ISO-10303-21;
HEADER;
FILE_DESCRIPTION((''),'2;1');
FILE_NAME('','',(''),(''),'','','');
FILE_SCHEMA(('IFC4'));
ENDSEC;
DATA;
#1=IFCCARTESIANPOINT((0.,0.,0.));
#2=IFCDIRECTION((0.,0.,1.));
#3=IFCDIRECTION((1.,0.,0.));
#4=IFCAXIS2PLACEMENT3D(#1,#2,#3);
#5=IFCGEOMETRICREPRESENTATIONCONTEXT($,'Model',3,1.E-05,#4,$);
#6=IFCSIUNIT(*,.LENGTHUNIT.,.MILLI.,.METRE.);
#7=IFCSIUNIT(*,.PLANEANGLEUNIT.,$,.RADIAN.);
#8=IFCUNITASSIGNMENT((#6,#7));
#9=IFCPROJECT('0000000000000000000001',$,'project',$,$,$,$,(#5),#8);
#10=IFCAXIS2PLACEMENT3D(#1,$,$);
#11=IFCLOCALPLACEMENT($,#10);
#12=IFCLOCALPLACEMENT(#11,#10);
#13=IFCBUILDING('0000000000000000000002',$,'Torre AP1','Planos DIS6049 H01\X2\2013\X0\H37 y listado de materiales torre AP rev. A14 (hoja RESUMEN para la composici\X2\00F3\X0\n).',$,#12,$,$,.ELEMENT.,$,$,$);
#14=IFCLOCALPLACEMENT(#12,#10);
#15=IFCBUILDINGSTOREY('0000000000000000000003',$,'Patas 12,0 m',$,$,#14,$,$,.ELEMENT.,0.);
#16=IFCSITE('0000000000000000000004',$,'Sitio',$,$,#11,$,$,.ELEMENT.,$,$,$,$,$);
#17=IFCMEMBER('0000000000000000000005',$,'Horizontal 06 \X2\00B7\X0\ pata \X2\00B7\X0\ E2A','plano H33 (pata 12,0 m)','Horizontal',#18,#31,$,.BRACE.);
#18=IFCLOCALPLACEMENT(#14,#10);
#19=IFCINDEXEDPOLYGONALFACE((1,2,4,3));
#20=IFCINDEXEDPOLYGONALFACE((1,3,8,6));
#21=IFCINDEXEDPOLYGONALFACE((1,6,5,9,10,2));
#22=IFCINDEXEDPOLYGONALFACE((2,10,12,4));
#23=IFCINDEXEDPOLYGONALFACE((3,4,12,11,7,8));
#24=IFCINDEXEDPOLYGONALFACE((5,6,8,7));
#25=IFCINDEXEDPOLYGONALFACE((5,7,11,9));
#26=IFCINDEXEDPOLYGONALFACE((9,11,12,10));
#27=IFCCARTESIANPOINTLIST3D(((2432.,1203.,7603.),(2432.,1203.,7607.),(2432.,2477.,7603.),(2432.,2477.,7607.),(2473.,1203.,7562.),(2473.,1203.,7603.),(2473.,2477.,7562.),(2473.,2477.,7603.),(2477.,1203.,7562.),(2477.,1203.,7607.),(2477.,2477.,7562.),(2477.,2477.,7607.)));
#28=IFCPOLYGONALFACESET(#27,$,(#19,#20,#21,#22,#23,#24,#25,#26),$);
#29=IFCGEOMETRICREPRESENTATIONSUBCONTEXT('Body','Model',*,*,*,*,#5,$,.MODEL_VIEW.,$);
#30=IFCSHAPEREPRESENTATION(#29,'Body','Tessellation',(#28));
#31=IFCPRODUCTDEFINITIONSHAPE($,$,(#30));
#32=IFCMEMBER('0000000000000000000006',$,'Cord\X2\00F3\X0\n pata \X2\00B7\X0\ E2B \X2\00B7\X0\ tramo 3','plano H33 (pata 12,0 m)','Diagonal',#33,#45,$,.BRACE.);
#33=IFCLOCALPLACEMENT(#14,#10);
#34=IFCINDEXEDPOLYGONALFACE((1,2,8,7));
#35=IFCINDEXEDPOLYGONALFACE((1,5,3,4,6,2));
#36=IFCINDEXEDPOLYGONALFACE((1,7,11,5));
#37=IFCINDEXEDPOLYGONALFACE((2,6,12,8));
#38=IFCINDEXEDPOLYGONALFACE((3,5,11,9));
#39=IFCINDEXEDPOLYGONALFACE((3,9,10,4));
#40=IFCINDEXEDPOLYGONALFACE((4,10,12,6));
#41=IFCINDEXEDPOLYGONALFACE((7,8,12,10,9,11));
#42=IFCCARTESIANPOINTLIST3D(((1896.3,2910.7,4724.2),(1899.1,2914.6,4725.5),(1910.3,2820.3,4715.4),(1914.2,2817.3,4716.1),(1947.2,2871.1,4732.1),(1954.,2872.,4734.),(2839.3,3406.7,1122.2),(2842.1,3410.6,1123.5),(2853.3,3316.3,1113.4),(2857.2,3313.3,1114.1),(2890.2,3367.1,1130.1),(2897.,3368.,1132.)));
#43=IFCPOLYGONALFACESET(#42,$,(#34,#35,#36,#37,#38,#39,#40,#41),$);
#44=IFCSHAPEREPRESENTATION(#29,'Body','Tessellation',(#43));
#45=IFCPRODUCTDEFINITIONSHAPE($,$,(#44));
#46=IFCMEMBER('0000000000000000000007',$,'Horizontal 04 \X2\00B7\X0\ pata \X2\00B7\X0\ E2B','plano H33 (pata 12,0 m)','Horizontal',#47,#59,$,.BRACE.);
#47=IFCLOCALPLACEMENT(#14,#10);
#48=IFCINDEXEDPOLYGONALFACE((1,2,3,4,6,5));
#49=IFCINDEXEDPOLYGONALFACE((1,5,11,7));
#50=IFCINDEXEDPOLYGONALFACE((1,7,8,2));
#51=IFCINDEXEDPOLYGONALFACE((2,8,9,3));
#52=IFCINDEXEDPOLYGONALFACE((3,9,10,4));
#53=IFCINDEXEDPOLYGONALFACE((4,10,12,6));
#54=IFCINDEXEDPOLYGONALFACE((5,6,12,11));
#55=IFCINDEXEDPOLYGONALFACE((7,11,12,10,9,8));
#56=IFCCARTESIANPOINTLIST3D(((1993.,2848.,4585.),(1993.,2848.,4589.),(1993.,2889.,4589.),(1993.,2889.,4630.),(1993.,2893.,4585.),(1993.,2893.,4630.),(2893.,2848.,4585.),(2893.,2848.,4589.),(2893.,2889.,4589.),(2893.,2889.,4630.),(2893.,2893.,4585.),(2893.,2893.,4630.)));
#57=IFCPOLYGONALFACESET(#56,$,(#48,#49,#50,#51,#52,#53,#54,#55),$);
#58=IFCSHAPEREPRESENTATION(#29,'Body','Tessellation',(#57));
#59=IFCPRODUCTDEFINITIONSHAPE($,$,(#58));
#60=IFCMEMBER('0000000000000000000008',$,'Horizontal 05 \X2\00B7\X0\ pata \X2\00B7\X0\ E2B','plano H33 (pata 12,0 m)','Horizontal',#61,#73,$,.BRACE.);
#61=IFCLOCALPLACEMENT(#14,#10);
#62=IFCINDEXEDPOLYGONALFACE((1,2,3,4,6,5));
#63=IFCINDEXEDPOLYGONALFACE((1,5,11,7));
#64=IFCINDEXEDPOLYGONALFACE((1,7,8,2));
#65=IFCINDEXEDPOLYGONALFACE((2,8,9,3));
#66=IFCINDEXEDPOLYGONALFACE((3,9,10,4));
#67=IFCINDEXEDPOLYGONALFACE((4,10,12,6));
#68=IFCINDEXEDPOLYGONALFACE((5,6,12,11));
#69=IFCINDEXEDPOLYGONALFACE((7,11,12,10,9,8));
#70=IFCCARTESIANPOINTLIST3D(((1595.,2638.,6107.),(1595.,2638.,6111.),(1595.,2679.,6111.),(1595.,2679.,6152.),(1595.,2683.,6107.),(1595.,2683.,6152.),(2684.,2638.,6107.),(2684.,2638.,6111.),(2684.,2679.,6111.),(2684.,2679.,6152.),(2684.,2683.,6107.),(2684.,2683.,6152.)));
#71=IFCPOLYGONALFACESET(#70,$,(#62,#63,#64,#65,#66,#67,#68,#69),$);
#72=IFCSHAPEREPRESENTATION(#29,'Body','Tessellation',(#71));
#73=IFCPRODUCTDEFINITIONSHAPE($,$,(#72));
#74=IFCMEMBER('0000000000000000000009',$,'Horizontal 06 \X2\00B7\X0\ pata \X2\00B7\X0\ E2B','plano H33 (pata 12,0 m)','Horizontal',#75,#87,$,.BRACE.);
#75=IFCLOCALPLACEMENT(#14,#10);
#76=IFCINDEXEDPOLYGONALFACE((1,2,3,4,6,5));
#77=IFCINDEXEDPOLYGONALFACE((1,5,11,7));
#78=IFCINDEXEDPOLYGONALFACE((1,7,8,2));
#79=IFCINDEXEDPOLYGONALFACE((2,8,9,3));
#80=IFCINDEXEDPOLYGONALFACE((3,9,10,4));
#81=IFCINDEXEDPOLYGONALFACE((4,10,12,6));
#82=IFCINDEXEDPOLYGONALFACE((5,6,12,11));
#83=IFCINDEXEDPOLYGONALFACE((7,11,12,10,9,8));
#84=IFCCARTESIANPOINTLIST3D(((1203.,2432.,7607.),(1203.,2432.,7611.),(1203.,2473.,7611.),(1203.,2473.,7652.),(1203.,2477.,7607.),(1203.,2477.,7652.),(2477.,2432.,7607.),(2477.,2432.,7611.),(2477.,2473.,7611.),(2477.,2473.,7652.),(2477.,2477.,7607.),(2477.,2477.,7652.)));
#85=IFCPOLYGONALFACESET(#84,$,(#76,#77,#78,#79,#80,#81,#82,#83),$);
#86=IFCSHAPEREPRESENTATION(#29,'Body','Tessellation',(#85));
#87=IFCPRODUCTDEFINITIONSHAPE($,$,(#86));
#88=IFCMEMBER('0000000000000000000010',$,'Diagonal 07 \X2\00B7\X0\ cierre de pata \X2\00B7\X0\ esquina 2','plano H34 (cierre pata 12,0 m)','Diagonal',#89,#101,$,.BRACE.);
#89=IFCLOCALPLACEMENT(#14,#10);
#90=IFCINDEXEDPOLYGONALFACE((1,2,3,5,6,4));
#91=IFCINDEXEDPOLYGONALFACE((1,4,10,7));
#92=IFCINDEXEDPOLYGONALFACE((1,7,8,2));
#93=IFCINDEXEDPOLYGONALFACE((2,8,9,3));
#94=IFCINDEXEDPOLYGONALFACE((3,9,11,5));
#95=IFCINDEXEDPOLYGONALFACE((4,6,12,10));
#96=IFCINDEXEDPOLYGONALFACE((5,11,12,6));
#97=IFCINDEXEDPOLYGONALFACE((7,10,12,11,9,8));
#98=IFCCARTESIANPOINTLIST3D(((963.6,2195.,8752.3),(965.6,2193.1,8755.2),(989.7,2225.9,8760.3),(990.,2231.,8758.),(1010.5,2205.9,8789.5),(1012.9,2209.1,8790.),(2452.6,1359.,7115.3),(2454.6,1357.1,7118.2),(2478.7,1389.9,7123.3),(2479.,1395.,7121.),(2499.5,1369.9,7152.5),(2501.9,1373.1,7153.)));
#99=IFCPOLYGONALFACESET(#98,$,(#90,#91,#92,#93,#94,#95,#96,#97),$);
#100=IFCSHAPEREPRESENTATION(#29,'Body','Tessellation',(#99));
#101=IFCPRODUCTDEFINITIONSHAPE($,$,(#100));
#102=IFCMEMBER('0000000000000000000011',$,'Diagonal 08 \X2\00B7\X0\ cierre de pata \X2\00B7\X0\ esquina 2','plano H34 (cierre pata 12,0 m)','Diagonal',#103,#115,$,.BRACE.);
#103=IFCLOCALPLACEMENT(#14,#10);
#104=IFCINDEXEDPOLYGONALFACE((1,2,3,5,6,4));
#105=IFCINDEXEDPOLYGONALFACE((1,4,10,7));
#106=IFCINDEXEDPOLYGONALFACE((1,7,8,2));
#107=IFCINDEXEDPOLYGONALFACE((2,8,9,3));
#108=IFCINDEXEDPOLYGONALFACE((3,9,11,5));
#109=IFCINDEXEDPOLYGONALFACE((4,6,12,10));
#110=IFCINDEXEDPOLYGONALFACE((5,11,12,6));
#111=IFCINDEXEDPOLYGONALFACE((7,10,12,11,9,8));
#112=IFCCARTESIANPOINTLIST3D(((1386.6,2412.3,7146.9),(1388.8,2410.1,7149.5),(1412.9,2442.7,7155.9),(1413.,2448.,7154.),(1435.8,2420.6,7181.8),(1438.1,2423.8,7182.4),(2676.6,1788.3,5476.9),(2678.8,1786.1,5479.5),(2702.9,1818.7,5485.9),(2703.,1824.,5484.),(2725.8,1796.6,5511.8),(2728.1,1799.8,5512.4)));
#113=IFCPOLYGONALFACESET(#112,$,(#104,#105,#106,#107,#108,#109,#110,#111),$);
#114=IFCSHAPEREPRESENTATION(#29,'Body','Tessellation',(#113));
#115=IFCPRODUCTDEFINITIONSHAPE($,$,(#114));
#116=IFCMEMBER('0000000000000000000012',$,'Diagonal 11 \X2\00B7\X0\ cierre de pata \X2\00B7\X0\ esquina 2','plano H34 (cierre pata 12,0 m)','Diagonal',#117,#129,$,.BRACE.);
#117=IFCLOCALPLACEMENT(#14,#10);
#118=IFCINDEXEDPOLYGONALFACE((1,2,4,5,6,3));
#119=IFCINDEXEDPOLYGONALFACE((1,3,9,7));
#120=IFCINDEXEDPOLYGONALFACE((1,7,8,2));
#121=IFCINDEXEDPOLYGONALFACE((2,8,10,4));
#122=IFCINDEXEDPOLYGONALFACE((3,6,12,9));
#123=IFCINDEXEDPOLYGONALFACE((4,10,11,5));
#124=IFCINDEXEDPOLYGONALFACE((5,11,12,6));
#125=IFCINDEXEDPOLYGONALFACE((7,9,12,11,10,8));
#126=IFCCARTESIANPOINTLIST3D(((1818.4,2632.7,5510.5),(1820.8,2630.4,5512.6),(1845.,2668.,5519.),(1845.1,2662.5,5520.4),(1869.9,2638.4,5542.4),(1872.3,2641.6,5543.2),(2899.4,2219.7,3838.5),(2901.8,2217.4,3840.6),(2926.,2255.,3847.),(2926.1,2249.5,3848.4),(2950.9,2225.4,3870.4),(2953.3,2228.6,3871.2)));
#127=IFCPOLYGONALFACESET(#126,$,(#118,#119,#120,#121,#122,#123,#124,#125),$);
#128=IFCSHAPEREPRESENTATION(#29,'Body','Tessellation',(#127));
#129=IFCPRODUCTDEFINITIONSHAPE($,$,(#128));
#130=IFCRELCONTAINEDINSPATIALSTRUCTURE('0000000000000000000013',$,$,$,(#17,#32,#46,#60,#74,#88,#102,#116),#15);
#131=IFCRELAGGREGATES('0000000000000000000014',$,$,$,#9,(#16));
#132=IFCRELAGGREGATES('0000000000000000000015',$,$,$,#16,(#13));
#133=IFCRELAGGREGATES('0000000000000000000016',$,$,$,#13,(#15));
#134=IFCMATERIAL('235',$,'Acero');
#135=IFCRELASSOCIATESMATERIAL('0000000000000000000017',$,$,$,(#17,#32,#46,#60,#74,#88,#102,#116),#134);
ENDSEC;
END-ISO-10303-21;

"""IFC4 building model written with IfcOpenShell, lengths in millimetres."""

from ifc_helpers import new_model, si_unit, frame, frame_2d, origin, origin_with_axes, place, context, subcontext, project, spatial, l_section, extrude, material, element, save


model = new_model("IFC4")

# Units and contexts
model_context = context("Model", 3, precision=1e-05, world=origin_with_axes())
body_context = subcontext(model_context, "Body", "Model", "MODEL_VIEW")
ifc_project = project(units=[si_unit("LENGTHUNIT", "METRE", prefix="MILLI"), si_unit("PLANEANGLEUNIT", "RADIAN")], contexts=[model_context])

# Site, building, storey
site_placement = place(None, origin())
site = spatial("IfcSite", under=ifc_project, at=site_placement, Name="Sitio", CompositionType="ELEMENT")
building_placement = place(site_placement, origin())
building = spatial("IfcBuilding", under=site, at=building_placement, Name="Torre AP1", Description="Planos DIS6049 H01–H37 y listado de materiales torre AP rev. A14 (hoja RESUMEN para la composición).", CompositionType="ELEMENT")
storey_placement = place(building_placement, origin())
storey = spatial("IfcBuildingStorey", under=building, at=storey_placement, Name="Patas 12,0 m", CompositionType="ELEMENT", Elevation=0.0)

# Members
ifc_material = material(Name="235", Category="Acero")
member_1_placement = place(storey_placement, frame((2477.0, 2477.0, 7607.0), z_axis=(0.0, -1.0, 0.0), x_axis=(-1.0, 0.0, 0.0)))
element("IfcMember", 1, at=member_1_placement, inside=storey, material=ifc_material, Name="Horizontal 06 · pata · E2A", Description="plano H33 (pata 12,0 m)", ObjectType="Horizontal", PredefinedType="BRACE", context=body_context, shape_type="SweptSolid", body=[
    extrude(l_section(Depth=45.0, Width=45.0, Thickness=4.0, at=frame_2d((22.5, 22.5))), None, (0.0, 0.0, 1.0), 1274.0),
])
member_2_placement = place(storey_placement, frame((1954.0, 2872.0, 4734.0), z_axis=(0.251046, 0.132045, -0.958926), x_axis=(-0.56819, -0.781925, -0.256424)))
element("IfcMember", 2, at=member_2_placement, inside=storey, material=ifc_material, Name="Cordón pata · E2B · tramo 3", Description="plano H33 (pata 12,0 m)", ObjectType="Diagonal", PredefinedType="BRACE", context=body_context, shape_type="SweptSolid", body=[
    extrude(l_section(Depth=70.0, Width=70.0, Thickness=5.0, at=frame_2d((35.0, 35.0))), None, (0.0, 0.0, 1.0), 3756.3),
])
member_3_placement = place(storey_placement, frame((2893.0, 2893.0, 4585.0), z_axis=(-1.0, 0.0, 0.0), x_axis=(0.0, -1.0, 0.0)))
element("IfcMember", 3, at=member_3_placement, inside=storey, material=ifc_material, Name="Horizontal 04 · pata · E2B", Description="plano H33 (pata 12,0 m)", ObjectType="Horizontal", PredefinedType="BRACE", context=body_context, shape_type="SweptSolid", body=[
    extrude(l_section(Depth=45.0, Width=45.0, Thickness=4.0, at=frame_2d((22.5, 22.5))), None, (0.0, 0.0, 1.0), 900.0),
])
member_4_placement = place(storey_placement, frame((2684.0, 2683.0, 6107.0), z_axis=(-1.0, 0.0, 0.0), x_axis=(0.0, -1.0, 0.0)))
element("IfcMember", 4, at=member_4_placement, inside=storey, material=ifc_material, Name="Horizontal 05 · pata · E2B", Description="plano H33 (pata 12,0 m)", ObjectType="Horizontal", PredefinedType="BRACE", context=body_context, shape_type="SweptSolid", body=[
    extrude(l_section(Depth=45.0, Width=45.0, Thickness=4.0, at=frame_2d((22.5, 22.5))), None, (0.0, 0.0, 1.0), 1089.0),
])
member_5_placement = place(storey_placement, frame((2477.0, 2477.0, 7607.0), z_axis=(-1.0, 0.0, 0.0), x_axis=(0.0, -1.0, 0.0)))
element("IfcMember", 5, at=member_5_placement, inside=storey, material=ifc_material, Name="Horizontal 06 · pata · E2B", Description="plano H33 (pata 12,0 m)", ObjectType="Horizontal", PredefinedType="BRACE", context=body_context, shape_type="SweptSolid", body=[
    extrude(l_section(Depth=45.0, Width=45.0, Thickness=4.0, at=frame_2d((22.5, 22.5))), None, (0.0, 0.0, 1.0), 1274.0),
])
member_6_placement = place(storey_placement, frame((2479.0, 1395.0, 7121.0), z_axis=(-0.629454, 0.353407, 0.692019), x_axis=(-0.587707, -0.799129, -0.126466)))
element("IfcMember", 6, at=member_6_placement, inside=storey, material=ifc_material, Name="Diagonal 07 · cierre de pata · esquina 2", Description="plano H34 (cierre pata 12,0 m)", ObjectType="Diagonal", PredefinedType="BRACE", context=body_context, shape_type="SweptSolid", body=[
    extrude(l_section(Depth=45.0, Width=45.0, Thickness=4.0, at=frame_2d((22.5, 22.5))), None, (0.0, 0.0, 1.0), 2365.5),
])
member_7_placement = place(storey_placement, frame((2703.0, 1824.0, 5484.0), z_axis=(-0.58622, 0.283567, 0.758905), x_axis=(-0.587278, -0.794021, -0.156957)))
element("IfcMember", 7, at=member_7_placement, inside=storey, material=ifc_material, Name="Diagonal 08 · cierre de pata · esquina 2", Description="plano H34 (cierre pata 12,0 m)", ObjectType="Diagonal", PredefinedType="BRACE", context=body_context, shape_type="SweptSolid", body=[
    extrude(l_section(Depth=45.0, Width=45.0, Thickness=4.0, at=frame_2d((22.5, 22.5))), None, (0.0, 0.0, 1.0), 2200.5),
])
member_8_placement = place(storey_placement, frame((2926.0, 2255.0, 3847.0), z_axis=(-0.531622, 0.203108, 0.822268), x_axis=(-0.591842, -0.783559, -0.189098)))
element("IfcMember", 8, at=member_8_placement, inside=storey, material=ifc_material, Name="Diagonal 11 · cierre de pata · esquina 2", Description="plano H34 (cierre pata 12,0 m)", ObjectType="Diagonal", PredefinedType="BRACE", context=body_context, shape_type="SweptSolid", body=[
    extrude(l_section(Depth=45.0, Width=45.0, Thickness=4.0, at=frame_2d((22.5, 22.5))), None, (0.0, 0.0, 1.0), 2033.4),
])

save(model, "model.ifc")
